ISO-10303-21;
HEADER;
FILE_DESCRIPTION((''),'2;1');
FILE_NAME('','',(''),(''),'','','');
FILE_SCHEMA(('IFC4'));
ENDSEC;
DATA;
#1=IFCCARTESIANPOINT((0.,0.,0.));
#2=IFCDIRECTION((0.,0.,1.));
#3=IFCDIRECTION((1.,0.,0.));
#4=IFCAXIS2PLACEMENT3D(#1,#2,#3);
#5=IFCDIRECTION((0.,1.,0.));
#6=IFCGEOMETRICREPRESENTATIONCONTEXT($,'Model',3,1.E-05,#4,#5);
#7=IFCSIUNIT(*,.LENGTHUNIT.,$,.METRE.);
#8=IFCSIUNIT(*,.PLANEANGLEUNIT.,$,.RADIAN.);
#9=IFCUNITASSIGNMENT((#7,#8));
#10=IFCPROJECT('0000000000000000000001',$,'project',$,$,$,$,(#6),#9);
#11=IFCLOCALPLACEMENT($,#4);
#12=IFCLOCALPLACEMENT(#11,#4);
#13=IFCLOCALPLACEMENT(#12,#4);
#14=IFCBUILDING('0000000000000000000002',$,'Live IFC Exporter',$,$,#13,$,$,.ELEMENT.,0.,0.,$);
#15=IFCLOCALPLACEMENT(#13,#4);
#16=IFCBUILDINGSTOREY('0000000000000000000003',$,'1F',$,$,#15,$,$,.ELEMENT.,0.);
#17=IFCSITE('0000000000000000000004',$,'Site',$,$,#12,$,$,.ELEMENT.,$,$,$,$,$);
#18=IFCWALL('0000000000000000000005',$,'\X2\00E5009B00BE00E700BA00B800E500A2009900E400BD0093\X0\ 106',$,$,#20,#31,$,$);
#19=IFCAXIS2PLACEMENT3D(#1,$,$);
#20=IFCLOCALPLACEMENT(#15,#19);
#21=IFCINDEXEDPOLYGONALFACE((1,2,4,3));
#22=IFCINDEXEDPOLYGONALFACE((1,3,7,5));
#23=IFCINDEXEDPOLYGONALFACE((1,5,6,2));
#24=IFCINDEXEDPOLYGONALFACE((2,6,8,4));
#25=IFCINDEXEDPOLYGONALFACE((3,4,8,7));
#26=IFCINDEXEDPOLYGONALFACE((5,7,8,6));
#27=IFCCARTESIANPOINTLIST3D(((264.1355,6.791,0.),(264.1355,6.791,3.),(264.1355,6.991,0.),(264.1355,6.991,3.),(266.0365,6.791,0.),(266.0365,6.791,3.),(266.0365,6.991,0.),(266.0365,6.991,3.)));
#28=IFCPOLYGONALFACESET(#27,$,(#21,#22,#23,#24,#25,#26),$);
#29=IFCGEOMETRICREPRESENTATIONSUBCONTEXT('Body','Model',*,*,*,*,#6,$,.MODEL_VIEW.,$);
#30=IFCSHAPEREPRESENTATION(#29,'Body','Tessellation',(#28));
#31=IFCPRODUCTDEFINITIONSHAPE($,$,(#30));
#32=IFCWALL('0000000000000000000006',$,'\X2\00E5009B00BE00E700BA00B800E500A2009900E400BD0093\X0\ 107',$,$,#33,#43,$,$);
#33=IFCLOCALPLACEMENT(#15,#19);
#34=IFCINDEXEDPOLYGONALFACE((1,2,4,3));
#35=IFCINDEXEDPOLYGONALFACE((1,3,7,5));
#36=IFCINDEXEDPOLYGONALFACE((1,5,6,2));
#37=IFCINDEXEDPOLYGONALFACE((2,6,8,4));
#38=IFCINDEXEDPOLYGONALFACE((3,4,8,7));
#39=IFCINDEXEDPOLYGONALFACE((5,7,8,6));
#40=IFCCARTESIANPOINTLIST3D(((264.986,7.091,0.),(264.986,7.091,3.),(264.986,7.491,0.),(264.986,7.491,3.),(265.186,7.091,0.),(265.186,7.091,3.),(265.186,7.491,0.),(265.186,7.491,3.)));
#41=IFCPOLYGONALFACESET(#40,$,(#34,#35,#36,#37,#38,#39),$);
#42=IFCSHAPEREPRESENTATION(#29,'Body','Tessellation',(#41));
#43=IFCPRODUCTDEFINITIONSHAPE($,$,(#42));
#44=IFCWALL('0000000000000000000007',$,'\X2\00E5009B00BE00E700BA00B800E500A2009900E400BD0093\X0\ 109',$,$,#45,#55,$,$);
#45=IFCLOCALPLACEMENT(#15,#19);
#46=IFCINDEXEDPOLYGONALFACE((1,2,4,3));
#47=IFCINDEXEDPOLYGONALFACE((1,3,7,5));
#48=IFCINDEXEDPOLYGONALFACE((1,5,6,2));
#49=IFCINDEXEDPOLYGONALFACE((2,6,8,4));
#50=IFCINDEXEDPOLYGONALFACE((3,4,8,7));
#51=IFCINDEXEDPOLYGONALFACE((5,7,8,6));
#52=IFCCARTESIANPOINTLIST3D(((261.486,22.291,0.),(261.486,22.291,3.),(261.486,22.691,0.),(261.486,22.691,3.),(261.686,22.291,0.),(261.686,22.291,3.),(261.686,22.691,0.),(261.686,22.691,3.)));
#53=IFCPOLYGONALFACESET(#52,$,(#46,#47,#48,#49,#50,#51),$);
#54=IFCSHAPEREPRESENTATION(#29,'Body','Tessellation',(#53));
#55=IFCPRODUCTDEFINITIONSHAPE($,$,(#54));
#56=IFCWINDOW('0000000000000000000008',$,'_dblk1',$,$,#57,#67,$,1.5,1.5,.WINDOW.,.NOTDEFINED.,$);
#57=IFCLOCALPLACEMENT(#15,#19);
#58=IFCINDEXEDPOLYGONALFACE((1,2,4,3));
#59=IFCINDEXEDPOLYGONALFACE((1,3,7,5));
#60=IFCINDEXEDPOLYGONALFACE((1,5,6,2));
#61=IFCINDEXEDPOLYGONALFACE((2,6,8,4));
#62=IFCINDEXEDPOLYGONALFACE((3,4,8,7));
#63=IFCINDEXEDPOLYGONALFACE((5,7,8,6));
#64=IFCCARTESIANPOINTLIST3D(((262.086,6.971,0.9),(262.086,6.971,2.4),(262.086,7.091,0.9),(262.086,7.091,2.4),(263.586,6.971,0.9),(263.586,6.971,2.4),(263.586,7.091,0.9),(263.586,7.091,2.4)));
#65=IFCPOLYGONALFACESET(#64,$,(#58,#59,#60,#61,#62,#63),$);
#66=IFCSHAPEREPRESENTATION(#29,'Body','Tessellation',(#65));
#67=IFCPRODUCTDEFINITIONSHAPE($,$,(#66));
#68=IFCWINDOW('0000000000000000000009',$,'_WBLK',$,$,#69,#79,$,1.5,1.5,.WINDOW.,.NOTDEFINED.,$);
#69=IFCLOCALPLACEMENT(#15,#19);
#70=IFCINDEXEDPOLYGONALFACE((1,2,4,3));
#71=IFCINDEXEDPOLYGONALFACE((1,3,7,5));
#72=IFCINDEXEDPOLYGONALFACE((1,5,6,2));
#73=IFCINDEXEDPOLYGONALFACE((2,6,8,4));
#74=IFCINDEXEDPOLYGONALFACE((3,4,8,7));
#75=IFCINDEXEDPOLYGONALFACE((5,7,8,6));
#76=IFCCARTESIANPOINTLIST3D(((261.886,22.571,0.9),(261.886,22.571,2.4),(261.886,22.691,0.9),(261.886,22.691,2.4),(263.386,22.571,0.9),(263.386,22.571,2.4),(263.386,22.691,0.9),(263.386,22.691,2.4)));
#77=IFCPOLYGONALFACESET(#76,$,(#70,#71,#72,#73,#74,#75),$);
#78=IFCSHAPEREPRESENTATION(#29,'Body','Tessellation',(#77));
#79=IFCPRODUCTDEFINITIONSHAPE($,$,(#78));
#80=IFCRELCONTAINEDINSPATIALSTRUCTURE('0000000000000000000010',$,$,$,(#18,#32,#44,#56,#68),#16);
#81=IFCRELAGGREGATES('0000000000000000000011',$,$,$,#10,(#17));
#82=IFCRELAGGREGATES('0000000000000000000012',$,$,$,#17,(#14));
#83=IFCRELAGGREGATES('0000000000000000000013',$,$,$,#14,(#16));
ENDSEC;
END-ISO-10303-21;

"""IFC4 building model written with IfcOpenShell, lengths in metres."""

from ifc_helpers import new_model, si_unit, direction, frame, frame_2d, origin_with_axes, place, context, subcontext, project, spatial, rectangle, extrude, element, save


model = new_model("IFC4")

# Units and contexts
model_context = context("Model", 3, precision=1e-05, world=origin_with_axes(), true_north=direction((0.0, 1.0, 0.0)))
body_context = subcontext(model_context, "Body", "Model", "MODEL_VIEW")
ifc_project = project(units=[si_unit("LENGTHUNIT", "METRE"), si_unit("PLANEANGLEUNIT", "RADIAN")], contexts=[model_context])

# Site, building, storey
placement = place(None, origin_with_axes())
site_placement = place(placement, origin_with_axes())
site = spatial("IfcSite", under=ifc_project, at=site_placement, Name="Site", CompositionType="ELEMENT")
building_placement = place(site_placement, origin_with_axes())
building = spatial("IfcBuilding", under=site, at=building_placement, Name="Live IFC Exporter", CompositionType="ELEMENT", ElevationOfRefHeight=0.0, ElevationOfTerrain=0.0)
storey_placement = place(building_placement, origin_with_axes())
storey = spatial("IfcBuildingStorey", under=building, at=storey_placement, Name="1F", CompositionType="ELEMENT", Elevation=0.0)

# Walls
wall_1_placement = place(storey_placement, frame((265.086, 6.891, 0.0), z_axis=(0.0, 0.0, 1.0), x_axis=(1.0, 0.0, 0.0)))
element("IfcWall", 1, at=wall_1_placement, inside=storey, Name="å\u009b¾çº¸å¢\u0099ä½\u0093 106", context=body_context, shape_type="SweptSolid", body=[
    extrude(rectangle(XDim=1.901, YDim=0.2, at=frame_2d((0.0, 0.0), x_axis=(1.0, 0.0, 0.0))), frame((0.0, 0.0, 0.0), z_axis=(0.0, 0.0, 1.0)), (0.0, 0.0, 1.0), 3.0),
])
for number, where, z_axis, x_axis, name in (
    (2, (265.086, 7.291, 0.0), (0.0, 0.0, 1.0), (0.0, -1.0, 0.0), "å\u009b¾çº¸å¢\u0099ä½\u0093 107"),
    (3, (261.586, 22.491, 0.0), (0.0, 0.0, 1.0), (0.0, 1.0, 0.0), "å\u009b¾çº¸å¢\u0099ä½\u0093 109"),
):
    element("IfcWall", number, at=place(storey_placement, frame(where, z_axis=z_axis, x_axis=x_axis)), inside=storey, Name=name, context=body_context, shape_type="SweptSolid", body=[
        extrude(rectangle(XDim=0.4, YDim=0.2, at=frame_2d((0.0, 0.0), x_axis=(1.0, 0.0, 0.0))), frame((0.0, 0.0, 0.0), z_axis=(0.0, 0.0, 1.0)), (0.0, 0.0, 1.0), 3.0),
    ])

# Windows
for number, where, z_axis, x_axis, name in (
    (4, (262.836, 7.031, 0.9), (0.0, 0.0, 1.0), (1.0, 0.0, 0.0), "_dblk1"),
    (5, (262.636, 22.631, 0.9), (0.0, 0.0, 1.0), (1.0, 0.0, 0.0), "_WBLK"),
):
    element("IfcWindow", number, at=place(storey_placement, frame(where, z_axis=z_axis, x_axis=x_axis)), inside=storey, Name=name, OverallHeight=1.5, OverallWidth=1.5, PartitioningType="NOTDEFINED", PredefinedType="WINDOW", context=body_context, shape_type="SweptSolid", body=[
        extrude(rectangle(XDim=1.5, YDim=0.12, at=frame_2d((0.0, 0.0), x_axis=(1.0, 0.0, 0.0))), frame((0.0, 0.0, 0.0), z_axis=(0.0, 0.0, 1.0)), (0.0, 0.0, 1.0), 1.5),
    ])

save(model, "model.ifc")
